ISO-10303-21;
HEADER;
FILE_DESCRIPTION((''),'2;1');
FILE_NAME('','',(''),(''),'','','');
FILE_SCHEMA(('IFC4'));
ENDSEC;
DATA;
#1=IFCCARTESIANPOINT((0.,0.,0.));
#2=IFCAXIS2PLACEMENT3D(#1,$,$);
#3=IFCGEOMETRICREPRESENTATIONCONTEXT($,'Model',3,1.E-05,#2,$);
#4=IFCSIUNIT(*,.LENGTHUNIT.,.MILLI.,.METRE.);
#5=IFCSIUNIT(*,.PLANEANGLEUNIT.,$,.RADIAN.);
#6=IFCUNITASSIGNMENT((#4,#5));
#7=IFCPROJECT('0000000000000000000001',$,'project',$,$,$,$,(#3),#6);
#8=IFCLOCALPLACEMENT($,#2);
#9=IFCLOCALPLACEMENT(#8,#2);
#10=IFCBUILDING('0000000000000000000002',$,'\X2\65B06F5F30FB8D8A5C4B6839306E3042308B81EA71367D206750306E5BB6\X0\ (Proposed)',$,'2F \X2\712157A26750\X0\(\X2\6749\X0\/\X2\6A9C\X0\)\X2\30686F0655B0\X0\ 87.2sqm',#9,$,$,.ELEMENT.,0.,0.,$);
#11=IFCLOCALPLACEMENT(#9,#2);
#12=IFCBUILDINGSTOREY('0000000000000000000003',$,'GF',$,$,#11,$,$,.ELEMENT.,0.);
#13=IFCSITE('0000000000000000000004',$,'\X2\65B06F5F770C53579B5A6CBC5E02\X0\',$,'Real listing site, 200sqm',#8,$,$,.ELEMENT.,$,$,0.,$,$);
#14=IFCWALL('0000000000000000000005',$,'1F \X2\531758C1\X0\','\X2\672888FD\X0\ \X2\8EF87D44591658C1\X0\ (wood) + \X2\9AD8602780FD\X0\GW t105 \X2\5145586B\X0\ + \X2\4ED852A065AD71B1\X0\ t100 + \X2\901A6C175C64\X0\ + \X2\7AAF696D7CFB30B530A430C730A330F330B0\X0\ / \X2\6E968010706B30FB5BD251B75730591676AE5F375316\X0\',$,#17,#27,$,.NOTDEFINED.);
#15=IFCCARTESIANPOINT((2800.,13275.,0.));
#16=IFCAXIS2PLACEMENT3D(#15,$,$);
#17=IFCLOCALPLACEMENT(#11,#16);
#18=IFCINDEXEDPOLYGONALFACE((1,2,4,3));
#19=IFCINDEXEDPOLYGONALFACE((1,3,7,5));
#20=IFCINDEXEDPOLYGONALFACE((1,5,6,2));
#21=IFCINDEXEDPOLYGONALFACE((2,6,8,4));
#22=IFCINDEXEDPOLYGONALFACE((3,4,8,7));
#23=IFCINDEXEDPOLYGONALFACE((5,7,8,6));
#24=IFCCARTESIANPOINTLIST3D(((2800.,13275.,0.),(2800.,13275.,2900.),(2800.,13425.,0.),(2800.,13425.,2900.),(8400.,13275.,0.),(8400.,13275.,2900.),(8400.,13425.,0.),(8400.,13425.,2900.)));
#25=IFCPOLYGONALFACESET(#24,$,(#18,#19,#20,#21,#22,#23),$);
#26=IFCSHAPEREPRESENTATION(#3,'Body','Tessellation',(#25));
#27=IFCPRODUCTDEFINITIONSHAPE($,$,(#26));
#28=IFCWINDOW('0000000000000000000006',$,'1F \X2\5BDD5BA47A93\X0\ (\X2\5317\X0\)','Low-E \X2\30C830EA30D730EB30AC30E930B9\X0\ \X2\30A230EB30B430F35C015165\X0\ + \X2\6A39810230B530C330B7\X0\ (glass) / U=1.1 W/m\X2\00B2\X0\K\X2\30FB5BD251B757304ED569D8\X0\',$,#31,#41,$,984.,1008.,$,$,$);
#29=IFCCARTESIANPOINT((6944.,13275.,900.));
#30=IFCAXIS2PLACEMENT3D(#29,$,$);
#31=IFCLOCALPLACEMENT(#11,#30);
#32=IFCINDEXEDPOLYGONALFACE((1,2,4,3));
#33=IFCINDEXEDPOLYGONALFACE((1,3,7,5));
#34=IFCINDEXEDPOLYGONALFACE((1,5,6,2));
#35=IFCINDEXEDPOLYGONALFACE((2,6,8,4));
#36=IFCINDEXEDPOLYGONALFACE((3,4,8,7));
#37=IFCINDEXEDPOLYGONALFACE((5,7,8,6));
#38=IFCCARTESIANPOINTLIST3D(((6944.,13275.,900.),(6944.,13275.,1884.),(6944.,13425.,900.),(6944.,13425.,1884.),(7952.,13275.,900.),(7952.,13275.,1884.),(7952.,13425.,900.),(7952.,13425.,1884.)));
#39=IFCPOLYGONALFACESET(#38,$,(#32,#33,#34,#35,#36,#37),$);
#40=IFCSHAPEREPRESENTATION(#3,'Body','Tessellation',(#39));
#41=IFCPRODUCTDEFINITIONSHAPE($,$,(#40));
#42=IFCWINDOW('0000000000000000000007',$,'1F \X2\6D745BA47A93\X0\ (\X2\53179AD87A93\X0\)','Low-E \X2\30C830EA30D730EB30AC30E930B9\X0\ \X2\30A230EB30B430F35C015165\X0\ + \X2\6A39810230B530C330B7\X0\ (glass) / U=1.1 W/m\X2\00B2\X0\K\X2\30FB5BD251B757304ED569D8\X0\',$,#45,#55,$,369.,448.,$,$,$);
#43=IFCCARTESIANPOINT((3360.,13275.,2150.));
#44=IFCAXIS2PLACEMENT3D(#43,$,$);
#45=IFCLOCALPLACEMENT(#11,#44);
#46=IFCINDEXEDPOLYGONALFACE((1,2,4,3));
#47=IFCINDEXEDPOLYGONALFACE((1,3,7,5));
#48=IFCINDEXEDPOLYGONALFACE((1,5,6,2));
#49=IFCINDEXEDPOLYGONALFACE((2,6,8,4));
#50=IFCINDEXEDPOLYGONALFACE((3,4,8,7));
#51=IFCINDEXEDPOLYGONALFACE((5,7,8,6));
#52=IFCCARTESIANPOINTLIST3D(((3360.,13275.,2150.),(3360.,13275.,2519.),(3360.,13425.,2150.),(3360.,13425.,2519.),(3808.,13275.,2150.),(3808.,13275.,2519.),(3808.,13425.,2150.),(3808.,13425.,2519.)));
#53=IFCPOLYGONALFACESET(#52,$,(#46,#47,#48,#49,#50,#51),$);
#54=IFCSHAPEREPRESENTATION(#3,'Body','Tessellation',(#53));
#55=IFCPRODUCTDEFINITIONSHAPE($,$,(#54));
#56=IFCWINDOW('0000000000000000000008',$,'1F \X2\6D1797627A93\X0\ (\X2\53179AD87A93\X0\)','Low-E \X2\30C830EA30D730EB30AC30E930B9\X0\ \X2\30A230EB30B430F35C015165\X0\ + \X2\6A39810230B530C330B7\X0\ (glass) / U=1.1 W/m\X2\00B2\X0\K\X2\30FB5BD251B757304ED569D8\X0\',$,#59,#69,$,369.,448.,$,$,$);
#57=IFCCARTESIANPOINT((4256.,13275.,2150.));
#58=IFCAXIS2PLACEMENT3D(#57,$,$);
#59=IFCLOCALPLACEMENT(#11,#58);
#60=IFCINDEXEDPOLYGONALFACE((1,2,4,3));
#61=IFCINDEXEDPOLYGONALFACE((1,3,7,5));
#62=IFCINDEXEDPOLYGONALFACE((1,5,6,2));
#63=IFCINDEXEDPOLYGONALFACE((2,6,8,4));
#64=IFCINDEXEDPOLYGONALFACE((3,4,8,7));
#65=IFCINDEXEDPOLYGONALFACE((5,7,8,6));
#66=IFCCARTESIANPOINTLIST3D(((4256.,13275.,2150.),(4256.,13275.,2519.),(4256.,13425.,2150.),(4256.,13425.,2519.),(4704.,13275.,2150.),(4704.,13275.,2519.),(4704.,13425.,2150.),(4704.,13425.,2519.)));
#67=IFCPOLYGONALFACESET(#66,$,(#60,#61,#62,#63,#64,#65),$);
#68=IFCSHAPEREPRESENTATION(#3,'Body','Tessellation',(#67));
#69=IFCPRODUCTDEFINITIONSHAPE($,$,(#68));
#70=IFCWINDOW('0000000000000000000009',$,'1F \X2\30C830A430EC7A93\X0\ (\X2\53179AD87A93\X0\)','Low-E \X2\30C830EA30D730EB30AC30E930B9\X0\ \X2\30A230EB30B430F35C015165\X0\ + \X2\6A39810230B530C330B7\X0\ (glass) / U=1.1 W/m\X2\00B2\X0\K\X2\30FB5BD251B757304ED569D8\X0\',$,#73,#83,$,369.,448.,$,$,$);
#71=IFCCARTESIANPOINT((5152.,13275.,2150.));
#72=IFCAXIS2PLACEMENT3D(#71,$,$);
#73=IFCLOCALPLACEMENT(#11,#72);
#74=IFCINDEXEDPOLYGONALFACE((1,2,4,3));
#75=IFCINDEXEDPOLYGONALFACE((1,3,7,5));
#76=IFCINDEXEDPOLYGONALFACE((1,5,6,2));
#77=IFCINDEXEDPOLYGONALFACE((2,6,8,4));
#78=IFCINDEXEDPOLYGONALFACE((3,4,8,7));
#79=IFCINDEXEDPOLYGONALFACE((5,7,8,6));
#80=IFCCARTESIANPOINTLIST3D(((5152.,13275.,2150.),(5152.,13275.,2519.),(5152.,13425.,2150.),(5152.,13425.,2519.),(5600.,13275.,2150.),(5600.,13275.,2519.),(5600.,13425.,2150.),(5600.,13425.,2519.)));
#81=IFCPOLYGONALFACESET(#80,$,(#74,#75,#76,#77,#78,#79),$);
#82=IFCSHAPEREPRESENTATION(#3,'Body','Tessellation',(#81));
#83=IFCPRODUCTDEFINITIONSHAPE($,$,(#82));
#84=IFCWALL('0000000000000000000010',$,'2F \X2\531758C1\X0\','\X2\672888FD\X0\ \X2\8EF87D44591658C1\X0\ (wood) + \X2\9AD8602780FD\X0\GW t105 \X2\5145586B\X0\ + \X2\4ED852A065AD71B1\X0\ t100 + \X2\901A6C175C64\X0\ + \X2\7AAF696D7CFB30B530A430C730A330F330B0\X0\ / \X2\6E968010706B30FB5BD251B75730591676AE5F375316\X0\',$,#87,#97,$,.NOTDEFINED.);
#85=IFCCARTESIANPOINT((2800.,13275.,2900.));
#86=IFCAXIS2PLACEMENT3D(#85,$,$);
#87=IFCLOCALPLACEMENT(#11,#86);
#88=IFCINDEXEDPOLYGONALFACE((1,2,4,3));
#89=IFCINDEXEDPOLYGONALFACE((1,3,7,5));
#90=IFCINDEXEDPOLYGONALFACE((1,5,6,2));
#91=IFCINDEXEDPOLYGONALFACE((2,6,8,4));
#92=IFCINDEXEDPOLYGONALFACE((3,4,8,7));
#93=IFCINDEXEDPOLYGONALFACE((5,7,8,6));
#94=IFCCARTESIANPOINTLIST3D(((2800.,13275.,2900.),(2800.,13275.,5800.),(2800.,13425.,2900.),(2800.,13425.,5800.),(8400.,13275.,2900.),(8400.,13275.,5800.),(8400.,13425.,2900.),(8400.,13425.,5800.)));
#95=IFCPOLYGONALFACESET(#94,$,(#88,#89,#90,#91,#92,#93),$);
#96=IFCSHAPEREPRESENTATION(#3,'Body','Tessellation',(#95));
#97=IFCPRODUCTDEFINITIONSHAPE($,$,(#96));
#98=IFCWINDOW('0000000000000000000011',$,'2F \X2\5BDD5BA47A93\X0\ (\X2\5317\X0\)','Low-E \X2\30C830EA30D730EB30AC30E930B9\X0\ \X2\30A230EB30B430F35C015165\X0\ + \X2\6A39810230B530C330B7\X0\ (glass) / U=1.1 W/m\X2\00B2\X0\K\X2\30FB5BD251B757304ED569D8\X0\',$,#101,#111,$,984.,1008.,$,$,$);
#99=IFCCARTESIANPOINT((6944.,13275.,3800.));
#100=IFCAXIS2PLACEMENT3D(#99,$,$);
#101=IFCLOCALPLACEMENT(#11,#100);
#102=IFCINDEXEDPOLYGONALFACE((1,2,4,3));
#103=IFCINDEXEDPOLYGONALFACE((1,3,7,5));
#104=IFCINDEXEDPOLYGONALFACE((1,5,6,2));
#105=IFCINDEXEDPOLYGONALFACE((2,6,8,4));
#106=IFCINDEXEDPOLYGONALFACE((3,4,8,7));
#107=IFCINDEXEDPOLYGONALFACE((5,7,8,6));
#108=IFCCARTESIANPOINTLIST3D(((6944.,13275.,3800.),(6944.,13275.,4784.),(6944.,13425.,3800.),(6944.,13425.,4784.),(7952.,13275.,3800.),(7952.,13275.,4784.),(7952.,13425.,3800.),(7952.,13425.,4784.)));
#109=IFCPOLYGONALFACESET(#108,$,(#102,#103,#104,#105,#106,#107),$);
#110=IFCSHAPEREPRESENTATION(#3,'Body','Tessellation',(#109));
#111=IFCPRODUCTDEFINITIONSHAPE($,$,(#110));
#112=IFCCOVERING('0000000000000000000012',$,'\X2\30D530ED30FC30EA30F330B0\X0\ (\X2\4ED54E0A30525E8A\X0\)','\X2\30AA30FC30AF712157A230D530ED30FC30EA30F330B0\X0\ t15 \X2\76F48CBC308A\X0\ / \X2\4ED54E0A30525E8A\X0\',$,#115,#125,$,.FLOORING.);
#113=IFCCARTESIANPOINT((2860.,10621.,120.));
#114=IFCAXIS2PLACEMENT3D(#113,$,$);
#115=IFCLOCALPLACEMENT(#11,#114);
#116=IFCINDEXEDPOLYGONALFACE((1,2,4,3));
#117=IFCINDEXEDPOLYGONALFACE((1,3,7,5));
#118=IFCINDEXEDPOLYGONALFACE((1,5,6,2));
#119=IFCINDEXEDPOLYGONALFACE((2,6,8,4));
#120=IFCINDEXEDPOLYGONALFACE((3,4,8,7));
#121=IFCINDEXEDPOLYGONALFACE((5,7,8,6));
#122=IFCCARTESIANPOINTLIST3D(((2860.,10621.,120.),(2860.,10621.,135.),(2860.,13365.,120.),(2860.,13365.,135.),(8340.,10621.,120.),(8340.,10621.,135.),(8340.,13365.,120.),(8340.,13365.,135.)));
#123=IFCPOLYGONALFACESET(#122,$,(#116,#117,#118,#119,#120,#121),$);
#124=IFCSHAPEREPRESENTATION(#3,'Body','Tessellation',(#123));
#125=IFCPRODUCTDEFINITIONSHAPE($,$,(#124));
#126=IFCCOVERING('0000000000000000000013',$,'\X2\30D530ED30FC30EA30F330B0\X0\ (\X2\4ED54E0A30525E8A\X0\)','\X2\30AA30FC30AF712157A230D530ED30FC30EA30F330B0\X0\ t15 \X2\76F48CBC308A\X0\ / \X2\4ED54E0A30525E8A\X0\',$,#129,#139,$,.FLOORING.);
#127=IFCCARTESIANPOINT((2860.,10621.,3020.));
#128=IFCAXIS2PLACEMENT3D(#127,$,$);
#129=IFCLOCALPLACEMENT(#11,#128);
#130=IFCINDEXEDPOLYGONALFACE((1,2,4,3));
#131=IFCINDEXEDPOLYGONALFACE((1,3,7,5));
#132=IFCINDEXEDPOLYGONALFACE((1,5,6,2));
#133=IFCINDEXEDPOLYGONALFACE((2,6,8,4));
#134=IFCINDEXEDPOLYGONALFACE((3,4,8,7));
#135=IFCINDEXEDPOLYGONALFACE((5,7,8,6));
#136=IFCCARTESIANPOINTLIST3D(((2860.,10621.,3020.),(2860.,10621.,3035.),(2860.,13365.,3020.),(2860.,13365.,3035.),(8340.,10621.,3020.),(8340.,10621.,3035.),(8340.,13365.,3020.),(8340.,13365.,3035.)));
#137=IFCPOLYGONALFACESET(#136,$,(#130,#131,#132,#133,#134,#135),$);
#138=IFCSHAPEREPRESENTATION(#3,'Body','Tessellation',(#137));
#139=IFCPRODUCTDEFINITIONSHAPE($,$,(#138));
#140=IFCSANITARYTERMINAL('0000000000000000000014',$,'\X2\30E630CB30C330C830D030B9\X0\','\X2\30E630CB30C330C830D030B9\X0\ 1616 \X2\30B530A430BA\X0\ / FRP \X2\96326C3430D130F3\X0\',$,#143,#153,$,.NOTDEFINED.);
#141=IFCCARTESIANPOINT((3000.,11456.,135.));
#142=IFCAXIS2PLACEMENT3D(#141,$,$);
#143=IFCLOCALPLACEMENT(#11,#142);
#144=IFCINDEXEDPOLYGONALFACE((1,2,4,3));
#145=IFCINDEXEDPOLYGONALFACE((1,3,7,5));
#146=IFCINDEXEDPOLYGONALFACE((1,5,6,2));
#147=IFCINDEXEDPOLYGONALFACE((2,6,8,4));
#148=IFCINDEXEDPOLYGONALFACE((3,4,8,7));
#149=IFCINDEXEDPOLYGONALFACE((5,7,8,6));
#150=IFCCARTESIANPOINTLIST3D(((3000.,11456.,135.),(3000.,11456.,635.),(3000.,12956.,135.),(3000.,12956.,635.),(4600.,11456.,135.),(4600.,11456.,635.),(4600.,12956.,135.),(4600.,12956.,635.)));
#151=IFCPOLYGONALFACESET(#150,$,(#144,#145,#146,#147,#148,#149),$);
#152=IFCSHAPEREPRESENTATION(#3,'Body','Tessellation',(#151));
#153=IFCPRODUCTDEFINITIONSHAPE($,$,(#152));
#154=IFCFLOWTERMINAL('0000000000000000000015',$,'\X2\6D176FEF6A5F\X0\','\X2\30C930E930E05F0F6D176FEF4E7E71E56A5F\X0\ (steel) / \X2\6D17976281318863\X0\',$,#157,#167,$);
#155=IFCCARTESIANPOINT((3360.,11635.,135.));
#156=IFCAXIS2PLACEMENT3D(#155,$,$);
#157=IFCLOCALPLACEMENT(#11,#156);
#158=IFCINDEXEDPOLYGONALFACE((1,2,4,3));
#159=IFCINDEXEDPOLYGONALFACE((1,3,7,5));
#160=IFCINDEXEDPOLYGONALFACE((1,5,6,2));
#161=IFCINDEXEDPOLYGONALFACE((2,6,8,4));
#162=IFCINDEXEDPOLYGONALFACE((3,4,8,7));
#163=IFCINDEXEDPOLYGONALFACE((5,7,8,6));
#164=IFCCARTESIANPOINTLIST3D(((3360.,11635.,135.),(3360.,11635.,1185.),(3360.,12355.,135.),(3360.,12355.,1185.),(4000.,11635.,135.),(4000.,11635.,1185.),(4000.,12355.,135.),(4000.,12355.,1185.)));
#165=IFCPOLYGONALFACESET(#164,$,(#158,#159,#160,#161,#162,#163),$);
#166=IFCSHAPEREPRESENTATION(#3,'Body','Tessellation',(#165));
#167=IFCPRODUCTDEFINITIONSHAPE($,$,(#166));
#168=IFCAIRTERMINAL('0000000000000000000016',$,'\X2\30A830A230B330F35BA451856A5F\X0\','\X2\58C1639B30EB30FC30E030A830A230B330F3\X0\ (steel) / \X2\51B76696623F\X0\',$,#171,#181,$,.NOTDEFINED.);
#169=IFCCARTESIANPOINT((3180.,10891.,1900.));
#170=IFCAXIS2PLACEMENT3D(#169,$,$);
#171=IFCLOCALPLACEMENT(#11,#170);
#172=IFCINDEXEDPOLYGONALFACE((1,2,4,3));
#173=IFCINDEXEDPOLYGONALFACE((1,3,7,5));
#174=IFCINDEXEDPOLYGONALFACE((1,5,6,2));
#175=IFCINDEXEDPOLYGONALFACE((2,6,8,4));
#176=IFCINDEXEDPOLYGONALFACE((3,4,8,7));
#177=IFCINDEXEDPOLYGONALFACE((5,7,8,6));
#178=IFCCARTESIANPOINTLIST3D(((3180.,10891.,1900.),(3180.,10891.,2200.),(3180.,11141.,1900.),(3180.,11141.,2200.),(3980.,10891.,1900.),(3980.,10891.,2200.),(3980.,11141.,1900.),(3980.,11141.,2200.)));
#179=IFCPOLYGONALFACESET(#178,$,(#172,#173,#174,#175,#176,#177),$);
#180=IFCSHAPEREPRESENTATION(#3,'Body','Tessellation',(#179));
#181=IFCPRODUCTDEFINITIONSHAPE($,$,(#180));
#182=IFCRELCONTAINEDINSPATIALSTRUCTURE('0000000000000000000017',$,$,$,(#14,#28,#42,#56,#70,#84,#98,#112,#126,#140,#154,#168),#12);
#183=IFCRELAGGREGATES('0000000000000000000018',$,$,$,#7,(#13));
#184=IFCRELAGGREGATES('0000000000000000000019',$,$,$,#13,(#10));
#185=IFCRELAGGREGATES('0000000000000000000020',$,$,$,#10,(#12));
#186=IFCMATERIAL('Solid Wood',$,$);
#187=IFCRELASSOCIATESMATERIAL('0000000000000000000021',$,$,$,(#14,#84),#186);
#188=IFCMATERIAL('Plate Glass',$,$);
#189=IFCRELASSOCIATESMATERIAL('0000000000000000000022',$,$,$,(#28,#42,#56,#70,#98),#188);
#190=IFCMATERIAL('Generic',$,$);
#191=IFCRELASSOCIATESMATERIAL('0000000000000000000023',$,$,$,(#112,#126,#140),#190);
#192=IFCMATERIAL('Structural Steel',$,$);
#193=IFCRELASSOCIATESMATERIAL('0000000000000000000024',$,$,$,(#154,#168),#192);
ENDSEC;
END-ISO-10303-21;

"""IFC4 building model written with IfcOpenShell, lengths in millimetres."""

from ifc_helpers import new_model, si_unit, frame, frame_2d, origin, place, context, project, spatial, rectangle, extrude, material, element, fill, save


model = new_model("IFC4")

# Units and contexts
model_context = context("Model", 3, precision=1e-05, world=origin())
ifc_project = project(units=[si_unit("LENGTHUNIT", "METRE", prefix="MILLI"), si_unit("PLANEANGLEUNIT", "RADIAN")], contexts=[model_context])

# Site, building, storey
site_placement = place(None, origin())
site = spatial("IfcSite", under=ifc_project, at=site_placement, Name="新潟県南魚沼市", ObjectType="Real listing site, 200sqm", CompositionType="ELEMENT", RefElevation=0.0)
building_placement = place(site_placement, origin())
building = spatial("IfcBuilding", under=site, at=building_placement, Name="新潟・越屋根のある自然素材の家 (Proposed)", ObjectType="2F 無垢材(杉/檜)と漆喰 87.2sqm", CompositionType="ELEMENT", ElevationOfRefHeight=0.0, ElevationOfTerrain=0.0)
storey_placement = place(building_placement, origin())
storey = spatial("IfcBuildingStorey", under=building, at=storey_placement, Name="GF", CompositionType="ELEMENT", Elevation=0.0)

# Shared definitions
ifc_material_1 = material(Name="Solid Wood")

# Wall, openings, windows
wall_1_placement = place(storey_placement, frame((2800.0, 13275.0, 0.0)))
wall_1 = element("IfcWall", 1, at=wall_1_placement, inside=storey, material=ifc_material_1, Name="1F 北壁", Description="木製 軸組外壁 (wood) + 高性能GW t105 充填 + 付加断熱 t100 + 通気層 + 窯業系サイディング / 準耐火・寒冷地外皮強化", PredefinedType="NOTDEFINED", context=model_context, shape_type="SweptSolid", body=[
    extrude(rectangle(XDim=5600.0, YDim=150.0, at=frame_2d((2800.0, 75.0))), frame((2800.0, 13275.0, 0.0)), (0.0, 0.0, 1.0), 2900.0),
])
opening_1_placement = place(storey_placement, frame((6944.0, 13275.0, 900.0)))
opening_1 = element("IfcOpeningElement", 2, at=opening_1_placement, cuts=wall_1, PredefinedType="NOTDEFINED", context=model_context, shape_type="SweptSolid", body=[
    extrude(rectangle(XDim=1008.0, YDim=150.0, at=frame_2d((504.0, 75.0))), frame((6944.0, 13275.0, 900.0)), (0.0, 0.0, 1.0), 984.0),
])
opening_2_placement = place(storey_placement, frame((3360.0, 13275.0, 2150.0)))
opening_2 = element("IfcOpeningElement", 3, at=opening_2_placement, cuts=wall_1, PredefinedType="NOTDEFINED", context=model_context, shape_type="SweptSolid", body=[
    extrude(rectangle(XDim=448.0, YDim=150.0, at=frame_2d((224.0, 75.0))), frame((3360.0, 13275.0, 2150.0)), (0.0, 0.0, 1.0), 369.0),
])
opening_3_placement = place(storey_placement, frame((4256.0, 13275.0, 2150.0)))
opening_3 = element("IfcOpeningElement", 4, at=opening_3_placement, cuts=wall_1, PredefinedType="NOTDEFINED", context=model_context, shape_type="SweptSolid", body=[
    extrude(rectangle(XDim=448.0, YDim=150.0, at=frame_2d((224.0, 75.0))), frame((4256.0, 13275.0, 2150.0)), (0.0, 0.0, 1.0), 369.0),
])
opening_4_placement = place(storey_placement, frame((5152.0, 13275.0, 2150.0)))
opening_4 = element("IfcOpeningElement", 5, at=opening_4_placement, cuts=wall_1, PredefinedType="NOTDEFINED", context=model_context, shape_type="SweptSolid", body=[
    extrude(rectangle(XDim=448.0, YDim=150.0, at=frame_2d((224.0, 75.0))), frame((5152.0, 13275.0, 2150.0)), (0.0, 0.0, 1.0), 369.0),
])
ifc_material_2 = material(Name="Plate Glass")
window_1_placement = place(storey_placement, frame((6944.0, 13275.0, 900.0)))
window_1 = element("IfcWindow", 6, at=window_1_placement, inside=storey, material=ifc_material_2, Name="1F 寝室窓 (北)", Description="Low-E トリプルガラス アルゴン封入 + 樹脂サッシ (glass) / U=1.1 W/m²K・寒冷地仕様", OverallHeight=984.0, OverallWidth=1008.0, context=model_context, shape_type="SweptSolid", body=[
    extrude(rectangle(XDim=1008.0, YDim=150.0, at=frame_2d((504.0, 75.0))), frame((6944.0, 13275.0, 900.0)), (0.0, 0.0, 1.0), 984.0),
])
fill(opening_1, window_1)
window_2_placement = place(storey_placement, frame((3360.0, 13275.0, 2150.0)))
window_2 = element("IfcWindow", 7, at=window_2_placement, inside=storey, material=ifc_material_2, Name="1F 浴室窓 (北高窓)", Description="Low-E トリプルガラス アルゴン封入 + 樹脂サッシ (glass) / U=1.1 W/m²K・寒冷地仕様", OverallHeight=369.0, OverallWidth=448.0, context=model_context, shape_type="SweptSolid", body=[
    extrude(rectangle(XDim=448.0, YDim=150.0, at=frame_2d((224.0, 75.0))), frame((3360.0, 13275.0, 2150.0)), (0.0, 0.0, 1.0), 369.0),
])
fill(opening_2, window_2)
window_3_placement = place(storey_placement, frame((4256.0, 13275.0, 2150.0)))
window_3 = element("IfcWindow", 8, at=window_3_placement, inside=storey, material=ifc_material_2, Name="1F 洗面窓 (北高窓)", Description="Low-E トリプルガラス アルゴン封入 + 樹脂サッシ (glass) / U=1.1 W/m²K・寒冷地仕様", OverallHeight=369.0, OverallWidth=448.0, context=model_context, shape_type="SweptSolid", body=[
    extrude(rectangle(XDim=448.0, YDim=150.0, at=frame_2d((224.0, 75.0))), frame((4256.0, 13275.0, 2150.0)), (0.0, 0.0, 1.0), 369.0),
])
fill(opening_3, window_3)
window_4_placement = place(storey_placement, frame((5152.0, 13275.0, 2150.0)))
window_4 = element("IfcWindow", 9, at=window_4_placement, inside=storey, material=ifc_material_2, Name="1F トイレ窓 (北高窓)", Description="Low-E トリプルガラス アルゴン封入 + 樹脂サッシ (glass) / U=1.1 W/m²K・寒冷地仕様", OverallHeight=369.0, OverallWidth=448.0, context=model_context, shape_type="SweptSolid", body=[
    extrude(rectangle(XDim=448.0, YDim=150.0, at=frame_2d((224.0, 75.0))), frame((5152.0, 13275.0, 2150.0)), (0.0, 0.0, 1.0), 369.0),
])
fill(opening_4, window_4)

# Wall, opening, window
wall_2_placement = place(storey_placement, frame((2800.0, 13275.0, 2900.0)))
wall_2 = element("IfcWall", 10, at=wall_2_placement, inside=storey, material=ifc_material_1, Name="2F 北壁", Description="木製 軸組外壁 (wood) + 高性能GW t105 充填 + 付加断熱 t100 + 通気層 + 窯業系サイディング / 準耐火・寒冷地外皮強化", PredefinedType="NOTDEFINED", context=model_context, shape_type="SweptSolid", body=[
    extrude(rectangle(XDim=5600.0, YDim=150.0, at=frame_2d((2800.0, 75.0))), frame((2800.0, 13275.0, 2900.0)), (0.0, 0.0, 1.0), 2900.0),
])
opening_5_placement = place(storey_placement, frame((6944.0, 13275.0, 3800.0)))
opening_5 = element("IfcOpeningElement", 11, at=opening_5_placement, cuts=wall_2, PredefinedType="NOTDEFINED", context=model_context, shape_type="SweptSolid", body=[
    extrude(rectangle(XDim=1008.0, YDim=150.0, at=frame_2d((504.0, 75.0))), frame((6944.0, 13275.0, 3800.0)), (0.0, 0.0, 1.0), 984.0),
])
window_5_placement = place(storey_placement, frame((6944.0, 13275.0, 3800.0)))
window_5 = element("IfcWindow", 12, at=window_5_placement, inside=storey, material=ifc_material_2, Name="2F 寝室窓 (北)", Description="Low-E トリプルガラス アルゴン封入 + 樹脂サッシ (glass) / U=1.1 W/m²K・寒冷地仕様", OverallHeight=984.0, OverallWidth=1008.0, context=model_context, shape_type="SweptSolid", body=[
    extrude(rectangle(XDim=1008.0, YDim=150.0, at=frame_2d((504.0, 75.0))), frame((6944.0, 13275.0, 3800.0)), (0.0, 0.0, 1.0), 984.0),
])
fill(opening_5, window_5)

# Coverings
ifc_material_3 = material(Name="Generic")
covering_1_placement = place(storey_placement, frame((2860.0, 10621.0, 120.0)))
element("IfcCovering", 13, at=covering_1_placement, inside=storey, material=ifc_material_3, Name="フローリング (仕上げ床)", Description="オーク無垢フローリング t15 直貼り / 仕上げ床", PredefinedType="FLOORING", context=model_context, shape_type="SweptSolid", body=[
    extrude(rectangle(XDim=5480.0, YDim=2744.0, at=frame_2d((2740.0, 1372.0))), frame((2860.0, 10621.0, 120.0)), (0.0, 0.0, 1.0), 15.0),
])
covering_2_placement = place(storey_placement, frame((2860.0, 10621.0, 3020.0)))
element("IfcCovering", 14, at=covering_2_placement, inside=storey, material=ifc_material_3, Name="フローリング (仕上げ床)", Description="オーク無垢フローリング t15 直貼り / 仕上げ床", PredefinedType="FLOORING", context=model_context, shape_type="SweptSolid", body=[
    extrude(rectangle(XDim=5480.0, YDim=2744.0, at=frame_2d((2740.0, 1372.0))), frame((2860.0, 10621.0, 3020.0)), (0.0, 0.0, 1.0), 15.0),
])

# Sanitary terminal
sanitary_terminal_placement = place(storey_placement, frame((3000.0, 11456.0, 135.0)))
element("IfcSanitaryTerminal", 15, at=sanitary_terminal_placement, inside=storey, material=ifc_material_3, Name="ユニットバス", Description="ユニットバス 1616 サイズ / FRP 防水パン", PredefinedType="NOTDEFINED", context=model_context, shape_type="SweptSolid", body=[
    extrude(rectangle(XDim=1600.0, YDim=1500.0, at=frame_2d((800.0, 750.0))), frame((3000.0, 11456.0, 135.0)), (0.0, 0.0, 1.0), 500.0),
])

# Flow terminal
ifc_material_4 = material(Name="Structural Steel")
flow_terminal_placement = place(storey_placement, frame((3360.0, 11635.0, 135.0)))
element("IfcFlowTerminal", 16, at=flow_terminal_placement, inside=storey, material=ifc_material_4, Name="洗濯機", Description="ドラム式洗濯乾燥機 (steel) / 洗面脱衣", context=model_context, shape_type="SweptSolid", body=[
    extrude(rectangle(XDim=640.0, YDim=720.0, at=frame_2d((320.0, 360.0))), frame((3360.0, 11635.0, 135.0)), (0.0, 0.0, 1.0), 1050.0),
])

# Air terminal
air_terminal_1_placement = place(storey_placement, frame((3180.0, 10891.0, 1900.0)))
element("IfcAirTerminal", 17, at=air_terminal_1_placement, inside=storey, material=ifc_material_4, Name="エアコン室内機", Description="壁掛ルームエアコン (steel) / 冷暖房", PredefinedType="NOTDEFINED", context=model_context, shape_type="SweptSolid", body=[
    extrude(rectangle(XDim=800.0, YDim=250.0, at=frame_2d((400.0, 125.0))), frame((3180.0, 10891.0, 1900.0)), (0.0, 0.0, 1.0), 300.0),
])

save(model, "model.ifc")
